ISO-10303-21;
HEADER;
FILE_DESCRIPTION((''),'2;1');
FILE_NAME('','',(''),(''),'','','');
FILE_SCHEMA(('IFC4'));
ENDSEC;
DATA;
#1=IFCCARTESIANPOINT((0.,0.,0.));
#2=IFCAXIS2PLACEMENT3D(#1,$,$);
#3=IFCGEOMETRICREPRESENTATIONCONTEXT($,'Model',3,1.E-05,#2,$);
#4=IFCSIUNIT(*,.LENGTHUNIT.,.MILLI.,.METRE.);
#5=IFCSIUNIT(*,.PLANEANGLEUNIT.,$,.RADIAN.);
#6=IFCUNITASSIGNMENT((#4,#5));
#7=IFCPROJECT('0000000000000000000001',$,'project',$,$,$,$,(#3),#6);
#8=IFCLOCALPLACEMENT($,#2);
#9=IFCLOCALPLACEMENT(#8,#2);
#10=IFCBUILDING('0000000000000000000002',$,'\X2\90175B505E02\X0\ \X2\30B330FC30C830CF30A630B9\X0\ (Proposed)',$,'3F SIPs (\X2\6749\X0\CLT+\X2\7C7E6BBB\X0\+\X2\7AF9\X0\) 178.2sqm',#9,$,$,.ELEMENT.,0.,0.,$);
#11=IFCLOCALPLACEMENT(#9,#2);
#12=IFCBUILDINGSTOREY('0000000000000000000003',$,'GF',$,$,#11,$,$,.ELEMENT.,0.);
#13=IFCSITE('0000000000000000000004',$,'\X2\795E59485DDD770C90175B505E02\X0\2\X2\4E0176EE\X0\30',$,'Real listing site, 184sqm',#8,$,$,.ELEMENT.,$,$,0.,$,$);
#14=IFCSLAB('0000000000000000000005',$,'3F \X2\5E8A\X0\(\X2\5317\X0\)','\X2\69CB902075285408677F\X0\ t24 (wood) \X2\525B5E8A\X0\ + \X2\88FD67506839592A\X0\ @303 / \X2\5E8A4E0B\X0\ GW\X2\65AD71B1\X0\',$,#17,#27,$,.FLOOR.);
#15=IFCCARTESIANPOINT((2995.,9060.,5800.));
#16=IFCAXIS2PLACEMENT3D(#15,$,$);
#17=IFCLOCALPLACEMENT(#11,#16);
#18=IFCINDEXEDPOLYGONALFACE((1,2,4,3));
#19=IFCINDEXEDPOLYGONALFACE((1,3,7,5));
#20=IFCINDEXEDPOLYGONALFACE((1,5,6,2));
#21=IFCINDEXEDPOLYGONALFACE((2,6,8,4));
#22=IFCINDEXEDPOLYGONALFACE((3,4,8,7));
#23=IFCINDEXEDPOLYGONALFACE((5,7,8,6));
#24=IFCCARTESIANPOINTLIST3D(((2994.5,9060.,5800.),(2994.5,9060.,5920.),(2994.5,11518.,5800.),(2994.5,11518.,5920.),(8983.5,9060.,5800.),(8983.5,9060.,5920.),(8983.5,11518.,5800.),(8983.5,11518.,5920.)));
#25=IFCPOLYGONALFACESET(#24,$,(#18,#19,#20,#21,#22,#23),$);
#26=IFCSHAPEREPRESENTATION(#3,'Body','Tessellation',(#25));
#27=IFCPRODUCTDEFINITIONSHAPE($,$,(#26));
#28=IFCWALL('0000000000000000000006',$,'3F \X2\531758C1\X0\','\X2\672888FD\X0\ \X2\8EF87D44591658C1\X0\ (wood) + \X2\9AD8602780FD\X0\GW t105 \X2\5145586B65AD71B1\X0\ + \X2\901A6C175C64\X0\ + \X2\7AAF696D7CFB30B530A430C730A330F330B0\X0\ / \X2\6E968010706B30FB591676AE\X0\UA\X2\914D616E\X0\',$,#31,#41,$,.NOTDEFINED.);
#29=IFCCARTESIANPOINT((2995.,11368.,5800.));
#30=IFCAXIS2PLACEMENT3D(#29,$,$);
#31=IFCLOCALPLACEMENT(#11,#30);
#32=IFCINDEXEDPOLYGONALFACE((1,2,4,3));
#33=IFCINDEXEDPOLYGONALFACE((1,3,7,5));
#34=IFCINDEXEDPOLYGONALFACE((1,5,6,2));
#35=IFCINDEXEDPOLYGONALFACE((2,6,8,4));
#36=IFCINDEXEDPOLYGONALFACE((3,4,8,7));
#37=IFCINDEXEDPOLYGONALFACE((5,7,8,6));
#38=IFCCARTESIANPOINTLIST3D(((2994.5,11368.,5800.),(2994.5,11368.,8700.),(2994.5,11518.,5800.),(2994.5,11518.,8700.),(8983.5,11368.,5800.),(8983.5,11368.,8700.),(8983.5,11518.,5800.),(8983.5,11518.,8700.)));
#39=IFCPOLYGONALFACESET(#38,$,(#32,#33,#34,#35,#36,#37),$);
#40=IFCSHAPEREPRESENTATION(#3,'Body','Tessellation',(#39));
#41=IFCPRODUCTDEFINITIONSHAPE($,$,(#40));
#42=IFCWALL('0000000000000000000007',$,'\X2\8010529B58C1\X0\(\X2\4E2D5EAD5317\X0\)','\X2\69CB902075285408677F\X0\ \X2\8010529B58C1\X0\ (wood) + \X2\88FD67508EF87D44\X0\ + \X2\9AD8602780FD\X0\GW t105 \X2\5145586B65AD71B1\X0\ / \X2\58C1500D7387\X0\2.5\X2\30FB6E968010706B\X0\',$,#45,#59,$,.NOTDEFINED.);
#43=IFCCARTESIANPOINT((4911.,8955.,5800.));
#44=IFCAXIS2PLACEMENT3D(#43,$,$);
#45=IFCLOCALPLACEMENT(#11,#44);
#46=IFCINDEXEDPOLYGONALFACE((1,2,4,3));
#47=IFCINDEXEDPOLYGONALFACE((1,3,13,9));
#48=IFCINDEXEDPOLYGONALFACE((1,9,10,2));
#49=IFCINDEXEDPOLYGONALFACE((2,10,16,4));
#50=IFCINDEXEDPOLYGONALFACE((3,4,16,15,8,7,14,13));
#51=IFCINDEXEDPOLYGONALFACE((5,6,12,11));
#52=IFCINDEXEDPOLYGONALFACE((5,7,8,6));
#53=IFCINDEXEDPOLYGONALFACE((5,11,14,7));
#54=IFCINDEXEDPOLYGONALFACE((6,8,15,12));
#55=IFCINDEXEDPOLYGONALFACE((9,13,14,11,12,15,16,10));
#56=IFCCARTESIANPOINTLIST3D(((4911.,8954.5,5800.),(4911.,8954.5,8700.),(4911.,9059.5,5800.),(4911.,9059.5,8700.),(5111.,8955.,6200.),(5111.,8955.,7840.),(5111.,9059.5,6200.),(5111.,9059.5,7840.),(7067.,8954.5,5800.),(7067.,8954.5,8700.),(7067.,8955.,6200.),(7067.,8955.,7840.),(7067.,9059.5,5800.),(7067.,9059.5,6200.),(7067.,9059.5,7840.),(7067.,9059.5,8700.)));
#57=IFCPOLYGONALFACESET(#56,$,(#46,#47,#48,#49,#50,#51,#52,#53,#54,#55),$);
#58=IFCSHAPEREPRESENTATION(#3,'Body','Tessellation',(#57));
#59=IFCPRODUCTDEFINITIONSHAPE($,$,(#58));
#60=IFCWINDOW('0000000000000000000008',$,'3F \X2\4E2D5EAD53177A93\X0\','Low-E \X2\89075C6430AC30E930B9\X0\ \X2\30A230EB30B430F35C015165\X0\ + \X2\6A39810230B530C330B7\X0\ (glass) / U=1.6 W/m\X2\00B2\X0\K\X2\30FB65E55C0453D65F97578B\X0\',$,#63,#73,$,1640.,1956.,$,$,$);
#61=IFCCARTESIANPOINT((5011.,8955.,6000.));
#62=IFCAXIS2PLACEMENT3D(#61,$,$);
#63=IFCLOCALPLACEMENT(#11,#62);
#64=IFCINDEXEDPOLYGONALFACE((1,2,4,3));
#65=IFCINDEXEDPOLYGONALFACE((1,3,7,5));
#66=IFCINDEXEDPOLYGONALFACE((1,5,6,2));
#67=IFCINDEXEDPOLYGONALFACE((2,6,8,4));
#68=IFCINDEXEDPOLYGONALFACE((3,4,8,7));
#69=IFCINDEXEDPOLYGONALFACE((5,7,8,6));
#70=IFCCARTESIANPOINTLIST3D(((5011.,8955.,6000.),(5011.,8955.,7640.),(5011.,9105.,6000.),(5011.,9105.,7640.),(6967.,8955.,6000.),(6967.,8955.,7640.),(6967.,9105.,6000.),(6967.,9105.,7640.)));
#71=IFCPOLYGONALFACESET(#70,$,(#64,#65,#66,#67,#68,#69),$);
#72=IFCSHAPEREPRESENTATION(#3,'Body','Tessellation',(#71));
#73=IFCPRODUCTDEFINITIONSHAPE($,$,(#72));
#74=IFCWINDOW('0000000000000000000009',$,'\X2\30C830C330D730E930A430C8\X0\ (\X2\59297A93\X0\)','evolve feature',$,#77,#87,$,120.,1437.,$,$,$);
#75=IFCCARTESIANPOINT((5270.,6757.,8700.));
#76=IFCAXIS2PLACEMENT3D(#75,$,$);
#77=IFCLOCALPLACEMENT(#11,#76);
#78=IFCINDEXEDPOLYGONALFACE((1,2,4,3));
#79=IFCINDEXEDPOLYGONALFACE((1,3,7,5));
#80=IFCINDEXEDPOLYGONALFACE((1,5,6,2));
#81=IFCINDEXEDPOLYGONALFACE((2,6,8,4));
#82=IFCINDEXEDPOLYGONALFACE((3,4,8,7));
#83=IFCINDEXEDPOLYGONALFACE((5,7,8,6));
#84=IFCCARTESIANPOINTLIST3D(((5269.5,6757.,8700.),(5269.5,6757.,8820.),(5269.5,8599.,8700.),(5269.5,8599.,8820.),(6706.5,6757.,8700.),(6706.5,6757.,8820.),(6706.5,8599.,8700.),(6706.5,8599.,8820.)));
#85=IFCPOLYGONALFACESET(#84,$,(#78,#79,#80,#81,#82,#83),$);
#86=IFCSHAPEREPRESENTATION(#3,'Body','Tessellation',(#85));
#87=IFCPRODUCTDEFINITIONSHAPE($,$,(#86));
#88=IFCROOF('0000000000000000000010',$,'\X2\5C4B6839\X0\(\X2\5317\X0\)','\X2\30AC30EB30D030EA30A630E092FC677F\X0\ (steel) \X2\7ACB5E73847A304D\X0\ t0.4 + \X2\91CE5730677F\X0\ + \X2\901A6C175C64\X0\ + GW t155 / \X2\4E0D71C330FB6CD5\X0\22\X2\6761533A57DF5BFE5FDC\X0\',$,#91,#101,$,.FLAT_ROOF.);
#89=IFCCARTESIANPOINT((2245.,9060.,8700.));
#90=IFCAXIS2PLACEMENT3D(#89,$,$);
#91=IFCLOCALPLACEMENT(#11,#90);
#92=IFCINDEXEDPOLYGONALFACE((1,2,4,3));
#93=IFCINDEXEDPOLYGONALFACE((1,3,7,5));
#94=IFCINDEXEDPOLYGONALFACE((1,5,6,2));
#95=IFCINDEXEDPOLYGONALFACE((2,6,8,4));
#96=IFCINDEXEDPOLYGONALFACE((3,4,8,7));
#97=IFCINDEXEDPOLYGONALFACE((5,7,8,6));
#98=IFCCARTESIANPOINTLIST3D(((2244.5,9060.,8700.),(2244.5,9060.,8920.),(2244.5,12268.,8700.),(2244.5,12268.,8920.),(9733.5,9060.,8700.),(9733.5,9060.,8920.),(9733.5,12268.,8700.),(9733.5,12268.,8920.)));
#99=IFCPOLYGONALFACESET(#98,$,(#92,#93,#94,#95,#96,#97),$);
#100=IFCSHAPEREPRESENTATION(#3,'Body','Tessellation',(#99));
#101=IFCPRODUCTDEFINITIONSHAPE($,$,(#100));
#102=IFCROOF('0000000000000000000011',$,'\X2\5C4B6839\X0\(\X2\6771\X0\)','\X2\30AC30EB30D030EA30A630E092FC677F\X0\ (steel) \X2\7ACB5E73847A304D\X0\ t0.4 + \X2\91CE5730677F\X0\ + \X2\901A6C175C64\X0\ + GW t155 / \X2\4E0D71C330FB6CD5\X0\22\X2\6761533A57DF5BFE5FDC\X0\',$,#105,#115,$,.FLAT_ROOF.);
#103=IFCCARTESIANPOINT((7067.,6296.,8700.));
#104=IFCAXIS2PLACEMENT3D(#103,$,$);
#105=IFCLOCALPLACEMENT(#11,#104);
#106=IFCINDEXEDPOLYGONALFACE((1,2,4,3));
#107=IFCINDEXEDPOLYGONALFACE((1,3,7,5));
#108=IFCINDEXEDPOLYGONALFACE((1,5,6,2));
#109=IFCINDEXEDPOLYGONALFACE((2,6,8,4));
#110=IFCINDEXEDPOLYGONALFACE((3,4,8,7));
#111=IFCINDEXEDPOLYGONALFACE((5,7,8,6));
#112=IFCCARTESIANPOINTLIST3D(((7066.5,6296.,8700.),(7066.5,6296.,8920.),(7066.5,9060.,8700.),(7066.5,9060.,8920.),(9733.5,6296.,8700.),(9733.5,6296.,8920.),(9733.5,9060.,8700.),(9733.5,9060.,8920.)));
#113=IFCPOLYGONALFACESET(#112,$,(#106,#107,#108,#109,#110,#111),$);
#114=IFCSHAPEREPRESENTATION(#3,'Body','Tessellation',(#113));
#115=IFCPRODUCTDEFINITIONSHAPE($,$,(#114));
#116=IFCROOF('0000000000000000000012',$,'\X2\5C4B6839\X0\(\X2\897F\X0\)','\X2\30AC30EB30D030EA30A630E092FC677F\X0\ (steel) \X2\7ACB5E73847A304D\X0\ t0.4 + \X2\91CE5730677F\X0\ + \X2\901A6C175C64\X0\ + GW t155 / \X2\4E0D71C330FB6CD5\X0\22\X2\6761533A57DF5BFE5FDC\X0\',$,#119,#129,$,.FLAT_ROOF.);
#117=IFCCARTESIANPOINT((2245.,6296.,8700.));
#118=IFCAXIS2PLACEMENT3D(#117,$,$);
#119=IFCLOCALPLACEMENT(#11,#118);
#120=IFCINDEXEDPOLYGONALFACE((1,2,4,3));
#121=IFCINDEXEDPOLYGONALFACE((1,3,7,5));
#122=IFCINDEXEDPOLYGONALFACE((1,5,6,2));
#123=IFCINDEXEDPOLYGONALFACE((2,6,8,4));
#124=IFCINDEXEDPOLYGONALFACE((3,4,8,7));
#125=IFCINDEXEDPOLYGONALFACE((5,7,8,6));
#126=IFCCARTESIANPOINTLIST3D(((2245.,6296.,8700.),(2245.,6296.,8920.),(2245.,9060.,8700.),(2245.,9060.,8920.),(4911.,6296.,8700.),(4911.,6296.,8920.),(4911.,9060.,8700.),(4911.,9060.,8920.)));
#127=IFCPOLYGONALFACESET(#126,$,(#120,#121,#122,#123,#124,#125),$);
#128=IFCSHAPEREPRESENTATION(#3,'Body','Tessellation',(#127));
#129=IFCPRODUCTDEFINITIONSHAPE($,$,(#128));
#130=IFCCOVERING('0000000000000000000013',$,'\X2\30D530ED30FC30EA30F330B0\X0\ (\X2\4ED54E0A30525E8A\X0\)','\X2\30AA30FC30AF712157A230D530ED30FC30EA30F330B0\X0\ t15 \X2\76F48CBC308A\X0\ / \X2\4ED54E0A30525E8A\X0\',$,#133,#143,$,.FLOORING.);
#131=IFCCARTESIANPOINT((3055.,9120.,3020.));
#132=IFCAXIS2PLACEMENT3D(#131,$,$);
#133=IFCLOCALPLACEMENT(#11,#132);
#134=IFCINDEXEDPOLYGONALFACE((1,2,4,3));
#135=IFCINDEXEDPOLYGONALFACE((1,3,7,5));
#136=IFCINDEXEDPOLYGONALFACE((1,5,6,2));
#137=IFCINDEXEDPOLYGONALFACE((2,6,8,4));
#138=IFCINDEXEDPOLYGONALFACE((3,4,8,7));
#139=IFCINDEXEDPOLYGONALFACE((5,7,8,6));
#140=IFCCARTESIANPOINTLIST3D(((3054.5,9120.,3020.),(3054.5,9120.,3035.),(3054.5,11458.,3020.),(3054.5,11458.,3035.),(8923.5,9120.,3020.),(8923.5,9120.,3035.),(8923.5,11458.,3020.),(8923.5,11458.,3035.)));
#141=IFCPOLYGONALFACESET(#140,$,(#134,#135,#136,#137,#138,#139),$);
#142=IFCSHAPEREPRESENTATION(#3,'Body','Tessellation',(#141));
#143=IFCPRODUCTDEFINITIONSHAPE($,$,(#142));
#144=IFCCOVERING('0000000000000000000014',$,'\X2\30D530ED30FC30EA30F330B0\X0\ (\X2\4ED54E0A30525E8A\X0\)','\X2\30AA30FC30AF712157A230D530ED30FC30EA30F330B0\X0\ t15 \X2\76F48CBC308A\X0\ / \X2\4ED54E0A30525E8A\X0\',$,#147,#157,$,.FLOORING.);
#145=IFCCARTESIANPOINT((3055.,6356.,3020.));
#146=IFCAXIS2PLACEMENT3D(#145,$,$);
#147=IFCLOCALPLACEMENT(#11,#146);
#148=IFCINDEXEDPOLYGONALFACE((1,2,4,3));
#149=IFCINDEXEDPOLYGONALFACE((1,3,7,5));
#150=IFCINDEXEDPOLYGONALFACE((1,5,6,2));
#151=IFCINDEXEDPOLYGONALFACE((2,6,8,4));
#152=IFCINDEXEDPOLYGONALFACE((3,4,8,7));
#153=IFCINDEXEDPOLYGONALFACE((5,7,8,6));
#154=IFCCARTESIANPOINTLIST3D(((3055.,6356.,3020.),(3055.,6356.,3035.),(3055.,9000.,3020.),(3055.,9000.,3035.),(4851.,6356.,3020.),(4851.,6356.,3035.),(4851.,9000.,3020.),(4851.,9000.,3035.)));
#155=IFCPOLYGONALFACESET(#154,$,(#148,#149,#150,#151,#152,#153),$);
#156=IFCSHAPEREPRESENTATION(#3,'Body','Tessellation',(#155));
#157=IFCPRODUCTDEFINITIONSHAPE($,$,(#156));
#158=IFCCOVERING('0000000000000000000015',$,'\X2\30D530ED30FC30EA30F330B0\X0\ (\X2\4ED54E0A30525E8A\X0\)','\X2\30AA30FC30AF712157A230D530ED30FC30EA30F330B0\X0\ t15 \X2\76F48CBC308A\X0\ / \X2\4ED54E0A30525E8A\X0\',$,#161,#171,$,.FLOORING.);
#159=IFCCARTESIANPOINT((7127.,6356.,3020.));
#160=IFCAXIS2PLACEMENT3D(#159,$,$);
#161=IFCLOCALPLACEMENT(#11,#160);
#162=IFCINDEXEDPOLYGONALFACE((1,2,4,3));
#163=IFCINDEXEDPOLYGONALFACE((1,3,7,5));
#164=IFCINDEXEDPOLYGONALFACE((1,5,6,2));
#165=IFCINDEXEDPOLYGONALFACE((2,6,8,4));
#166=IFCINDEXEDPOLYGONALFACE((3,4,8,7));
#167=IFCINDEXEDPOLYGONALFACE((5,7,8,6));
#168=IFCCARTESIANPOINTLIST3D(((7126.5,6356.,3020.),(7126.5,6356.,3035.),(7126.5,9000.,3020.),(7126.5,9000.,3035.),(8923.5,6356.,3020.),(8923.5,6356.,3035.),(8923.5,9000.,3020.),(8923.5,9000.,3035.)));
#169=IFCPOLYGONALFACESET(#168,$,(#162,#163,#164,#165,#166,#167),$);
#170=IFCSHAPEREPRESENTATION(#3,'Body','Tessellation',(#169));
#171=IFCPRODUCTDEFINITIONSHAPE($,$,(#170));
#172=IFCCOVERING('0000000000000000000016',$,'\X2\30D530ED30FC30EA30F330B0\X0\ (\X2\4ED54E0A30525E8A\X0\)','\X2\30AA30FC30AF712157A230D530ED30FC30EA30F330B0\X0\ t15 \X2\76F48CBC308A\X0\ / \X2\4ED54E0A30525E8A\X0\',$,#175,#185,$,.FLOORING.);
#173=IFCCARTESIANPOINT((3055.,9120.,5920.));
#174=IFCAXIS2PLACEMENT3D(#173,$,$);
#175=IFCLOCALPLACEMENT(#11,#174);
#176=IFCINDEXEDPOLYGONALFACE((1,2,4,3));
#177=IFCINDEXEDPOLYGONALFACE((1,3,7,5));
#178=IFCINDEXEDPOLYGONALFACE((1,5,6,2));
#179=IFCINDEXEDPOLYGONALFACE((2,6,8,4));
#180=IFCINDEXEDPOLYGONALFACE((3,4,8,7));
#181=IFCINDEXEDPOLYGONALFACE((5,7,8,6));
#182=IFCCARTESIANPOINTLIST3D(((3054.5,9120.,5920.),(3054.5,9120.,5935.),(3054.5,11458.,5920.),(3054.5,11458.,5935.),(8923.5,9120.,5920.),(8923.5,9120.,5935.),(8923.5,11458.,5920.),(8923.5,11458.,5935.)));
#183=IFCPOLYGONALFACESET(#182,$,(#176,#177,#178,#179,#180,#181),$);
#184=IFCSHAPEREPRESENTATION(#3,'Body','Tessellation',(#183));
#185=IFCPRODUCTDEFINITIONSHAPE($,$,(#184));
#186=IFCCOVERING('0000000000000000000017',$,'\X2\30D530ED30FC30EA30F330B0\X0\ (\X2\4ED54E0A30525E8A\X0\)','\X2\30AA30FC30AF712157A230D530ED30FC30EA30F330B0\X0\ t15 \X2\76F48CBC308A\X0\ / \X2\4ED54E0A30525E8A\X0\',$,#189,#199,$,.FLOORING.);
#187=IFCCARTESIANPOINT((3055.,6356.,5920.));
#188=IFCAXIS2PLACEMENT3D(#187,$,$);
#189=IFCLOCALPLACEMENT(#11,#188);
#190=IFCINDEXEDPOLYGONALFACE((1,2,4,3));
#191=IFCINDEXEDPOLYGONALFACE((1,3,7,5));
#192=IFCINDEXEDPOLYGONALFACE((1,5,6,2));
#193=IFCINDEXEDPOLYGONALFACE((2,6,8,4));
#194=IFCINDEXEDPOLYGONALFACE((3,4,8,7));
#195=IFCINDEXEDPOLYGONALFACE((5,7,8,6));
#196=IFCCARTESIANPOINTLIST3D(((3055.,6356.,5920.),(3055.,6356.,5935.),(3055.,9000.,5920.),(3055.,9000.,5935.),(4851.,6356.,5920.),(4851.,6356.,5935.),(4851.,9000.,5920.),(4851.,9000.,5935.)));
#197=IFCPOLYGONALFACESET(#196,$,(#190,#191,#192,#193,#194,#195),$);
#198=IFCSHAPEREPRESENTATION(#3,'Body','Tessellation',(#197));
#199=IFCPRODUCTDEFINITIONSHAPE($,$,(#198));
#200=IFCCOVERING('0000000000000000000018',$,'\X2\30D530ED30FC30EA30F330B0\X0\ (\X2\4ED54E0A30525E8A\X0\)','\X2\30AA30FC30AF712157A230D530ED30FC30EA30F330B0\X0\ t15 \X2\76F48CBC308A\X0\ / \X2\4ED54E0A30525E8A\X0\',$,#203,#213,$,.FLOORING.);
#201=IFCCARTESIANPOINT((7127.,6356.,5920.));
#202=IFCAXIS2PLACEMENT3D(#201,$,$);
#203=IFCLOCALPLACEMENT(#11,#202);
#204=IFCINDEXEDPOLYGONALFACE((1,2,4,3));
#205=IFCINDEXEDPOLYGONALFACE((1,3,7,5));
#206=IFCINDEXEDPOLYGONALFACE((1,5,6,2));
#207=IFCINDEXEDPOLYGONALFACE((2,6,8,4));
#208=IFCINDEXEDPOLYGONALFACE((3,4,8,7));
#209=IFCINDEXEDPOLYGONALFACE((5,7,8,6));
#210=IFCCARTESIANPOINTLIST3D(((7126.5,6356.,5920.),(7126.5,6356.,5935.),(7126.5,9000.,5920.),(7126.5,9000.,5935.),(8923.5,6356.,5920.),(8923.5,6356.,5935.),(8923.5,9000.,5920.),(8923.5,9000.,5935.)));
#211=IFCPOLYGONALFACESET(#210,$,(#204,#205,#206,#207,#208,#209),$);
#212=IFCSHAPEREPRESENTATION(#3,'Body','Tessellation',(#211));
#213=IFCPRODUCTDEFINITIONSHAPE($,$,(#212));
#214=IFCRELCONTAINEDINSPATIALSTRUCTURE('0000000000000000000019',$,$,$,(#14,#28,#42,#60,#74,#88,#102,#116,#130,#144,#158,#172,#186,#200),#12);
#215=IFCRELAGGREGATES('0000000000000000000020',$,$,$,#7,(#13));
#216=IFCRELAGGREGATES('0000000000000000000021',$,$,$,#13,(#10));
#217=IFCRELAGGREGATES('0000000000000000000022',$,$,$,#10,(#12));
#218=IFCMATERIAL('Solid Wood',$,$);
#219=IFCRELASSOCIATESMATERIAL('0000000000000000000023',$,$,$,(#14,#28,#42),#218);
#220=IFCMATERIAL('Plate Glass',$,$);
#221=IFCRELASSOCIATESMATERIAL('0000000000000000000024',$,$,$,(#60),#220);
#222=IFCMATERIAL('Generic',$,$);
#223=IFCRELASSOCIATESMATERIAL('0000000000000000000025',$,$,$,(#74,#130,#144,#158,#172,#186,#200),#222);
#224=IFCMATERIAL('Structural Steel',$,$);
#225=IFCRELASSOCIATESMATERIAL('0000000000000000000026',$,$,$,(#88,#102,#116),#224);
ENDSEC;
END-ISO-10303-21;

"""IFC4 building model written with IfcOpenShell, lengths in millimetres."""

from ifc_helpers import new_model, si_unit, frame, frame_2d, origin, place, context, project, spatial, rectangle, extrude, material, element, fill, save


model = new_model("IFC4")

# Units and contexts
model_context = context("Model", 3, precision=1e-05, world=origin())
ifc_project = project(units=[si_unit("LENGTHUNIT", "METRE", prefix="MILLI"), si_unit("PLANEANGLEUNIT", "RADIAN")], contexts=[model_context])

# Site, building, storey
site_placement = place(None, origin())
site = spatial("IfcSite", under=ifc_project, at=site_placement, Name="神奈川県逗子市2丁目30", ObjectType="Real listing site, 184sqm", CompositionType="ELEMENT", RefElevation=0.0)
building_placement = place(site_placement, origin())
building = spatial("IfcBuilding", under=site, at=building_placement, Name="逗子市 コートハウス (Proposed)", ObjectType="3F SIPs (杉CLT+籾殻+竹) 178.2sqm", CompositionType="ELEMENT", ElevationOfRefHeight=0.0, ElevationOfTerrain=0.0)
storey_placement = place(building_placement, origin())
storey = spatial("IfcBuildingStorey", under=building, at=storey_placement, Name="GF", CompositionType="ELEMENT", Elevation=0.0)

# Slab
ifc_material_1 = material(Name="Solid Wood")
slab_placement = place(storey_placement, frame((2995.0, 9060.0, 5800.0)))
element("IfcSlab", 1, at=slab_placement, inside=storey, material=ifc_material_1, Name="3F 床(北)", Description="構造用合板 t24 (wood) 剛床 + 製材根太 @303 / 床下 GW断熱", PredefinedType="FLOOR", context=model_context, shape_type="SweptSolid", body=[
    extrude(rectangle(XDim=5989.0, YDim=2458.0, at=frame_2d((2994.0, 1229.0))), frame((2995.0, 9060.0, 5800.0)), (0.0, 0.0, 1.0), 120.0),
])

# Wall
wall_1_placement = place(storey_placement, frame((2995.0, 11368.0, 5800.0)))
element("IfcWall", 2, at=wall_1_placement, inside=storey, material=ifc_material_1, Name="3F 北壁", Description="木製 軸組外壁 (wood) + 高性能GW t105 充填断熱 + 通気層 + 窯業系サイディング / 準耐火・外皮UA配慮", PredefinedType="NOTDEFINED", context=model_context, shape_type="SweptSolid", body=[
    extrude(rectangle(XDim=5989.0, YDim=150.0, at=frame_2d((2994.0, 75.0))), frame((2995.0, 11368.0, 5800.0)), (0.0, 0.0, 1.0), 2900.0),
])

# Wall, opening, window
wall_2_placement = place(storey_placement, frame((4911.0, 8955.0, 5800.0)))
wall_2 = element("IfcWall", 3, at=wall_2_placement, inside=storey, material=ifc_material_1, Name="耐力壁(中庭北)", Description="構造用合板 耐力壁 (wood) + 製材軸組 + 高性能GW t105 充填断熱 / 壁倍率2.5・準耐火", PredefinedType="NOTDEFINED", context=model_context, shape_type="SweptSolid", body=[
    extrude(rectangle(XDim=2156.0, YDim=105.0, at=frame_2d((1078.0, 52.0))), frame((4911.0, 8955.0, 5800.0)), (0.0, 0.0, 1.0), 2900.0),
])
opening_placement = place(storey_placement, frame((5011.0, 8955.0, 6000.0)))
opening = element("IfcOpeningElement", 4, at=opening_placement, cuts=wall_2, PredefinedType="NOTDEFINED", context=model_context, shape_type="SweptSolid", body=[
    extrude(rectangle(XDim=1956.0, YDim=150.0, at=frame_2d((978.0, 75.0))), frame((5011.0, 8955.0, 6000.0)), (0.0, 0.0, 1.0), 1640.0),
])
ifc_material_2 = material(Name="Plate Glass")
window_1_placement = place(storey_placement, frame((5011.0, 8955.0, 6000.0)))
window_1 = element("IfcWindow", 5, at=window_1_placement, inside=storey, material=ifc_material_2, Name="3F 中庭北窓", Description="Low-E 複層ガラス アルゴン封入 + 樹脂サッシ (glass) / U=1.6 W/m²K・日射取得型", OverallHeight=1640.0, OverallWidth=1956.0, context=model_context, shape_type="SweptSolid", body=[
    extrude(rectangle(XDim=1956.0, YDim=150.0, at=frame_2d((978.0, 75.0))), frame((5011.0, 8955.0, 6000.0)), (0.0, 0.0, 1.0), 1640.0),
])
fill(opening, window_1)

# Window
ifc_material_3 = material(Name="Generic")
window_2_placement = place(storey_placement, frame((5270.0, 6757.0, 8700.0)))
element("IfcWindow", 6, at=window_2_placement, inside=storey, material=ifc_material_3, Name="トップライト (天窓)", Description="evolve feature", OverallHeight=120.0, OverallWidth=1437.0, context=model_context, shape_type="SweptSolid", body=[
    extrude(rectangle(XDim=1437.0, YDim=1842.0, at=frame_2d((718.0, 921.0))), frame((5270.0, 6757.0, 8700.0)), (0.0, 0.0, 1.0), 120.0),
])

# Roofs
ifc_material_4 = material(Name="Structural Steel")
roof_1_placement = place(storey_placement, frame((2245.0, 9060.0, 8700.0)))
element("IfcRoof", 7, at=roof_1_placement, inside=storey, material=ifc_material_4, Name="屋根(北)", Description="ガルバリウム鋼板 (steel) 立平葺き t0.4 + 野地板 + 通気層 + GW t155 / 不燃・法22条区域対応", PredefinedType="FLAT_ROOF", context=model_context, shape_type="SweptSolid", body=[
    extrude(rectangle(XDim=7489.0, YDim=3208.0, at=frame_2d((3744.0, 1604.0))), frame((2245.0, 9060.0, 8700.0)), (0.0, 0.0, 1.0), 220.0),
])
roof_2_placement = place(storey_placement, frame((7067.0, 6296.0, 8700.0)))
element("IfcRoof", 8, at=roof_2_placement, inside=storey, material=ifc_material_4, Name="屋根(東)", Description="ガルバリウム鋼板 (steel) 立平葺き t0.4 + 野地板 + 通気層 + GW t155 / 不燃・法22条区域対応", PredefinedType="FLAT_ROOF", context=model_context, shape_type="SweptSolid", body=[
    extrude(rectangle(XDim=2667.0, YDim=2764.0, at=frame_2d((1333.0, 1382.0))), frame((7067.0, 6296.0, 8700.0)), (0.0, 0.0, 1.0), 220.0),
])
roof_3_placement = place(storey_placement, frame((2245.0, 6296.0, 8700.0)))
element("IfcRoof", 9, at=roof_3_placement, inside=storey, material=ifc_material_4, Name="屋根(西)", Description="ガルバリウム鋼板 (steel) 立平葺き t0.4 + 野地板 + 通気層 + GW t155 / 不燃・法22条区域対応", PredefinedType="FLAT_ROOF", context=model_context, shape_type="SweptSolid", body=[
    extrude(rectangle(XDim=2666.0, YDim=2764.0, at=frame_2d((1333.0, 1382.0))), frame((2245.0, 6296.0, 8700.0)), (0.0, 0.0, 1.0), 220.0),
])

# Coverings
covering_1_placement = place(storey_placement, frame((3055.0, 9120.0, 3020.0)))
element("IfcCovering", 10, at=covering_1_placement, inside=storey, material=ifc_material_3, Name="フローリング (仕上げ床)", Description="オーク無垢フローリング t15 直貼り / 仕上げ床", PredefinedType="FLOORING", context=model_context, shape_type="SweptSolid", body=[
    extrude(rectangle(XDim=5869.0, YDim=2338.0, at=frame_2d((2934.0, 1169.0))), frame((3055.0, 9120.0, 3020.0)), (0.0, 0.0, 1.0), 15.0),
])
covering_2_placement = place(storey_placement, frame((3055.0, 6356.0, 3020.0)))
element("IfcCovering", 11, at=covering_2_placement, inside=storey, material=ifc_material_3, Name="フローリング (仕上げ床)", Description="オーク無垢フローリング t15 直貼り / 仕上げ床", PredefinedType="FLOORING", context=model_context, shape_type="SweptSolid", body=[
    extrude(rectangle(XDim=1796.0, YDim=2644.0, at=frame_2d((898.0, 1322.0))), frame((3055.0, 6356.0, 3020.0)), (0.0, 0.0, 1.0), 15.0),
])
covering_3_placement = place(storey_placement, frame((7127.0, 6356.0, 3020.0)))
element("IfcCovering", 12, at=covering_3_placement, inside=storey, material=ifc_material_3, Name="フローリング (仕上げ床)", Description="オーク無垢フローリング t15 直貼り / 仕上げ床", PredefinedType="FLOORING", context=model_context, shape_type="SweptSolid", body=[
    extrude(rectangle(XDim=1797.0, YDim=2644.0, at=frame_2d((898.0, 1322.0))), frame((7127.0, 6356.0, 3020.0)), (0.0, 0.0, 1.0), 15.0),
])
covering_4_placement = place(storey_placement, frame((3055.0, 9120.0, 5920.0)))
element("IfcCovering", 13, at=covering_4_placement, inside=storey, material=ifc_material_3, Name="フローリング (仕上げ床)", Description="オーク無垢フローリング t15 直貼り / 仕上げ床", PredefinedType="FLOORING", context=model_context, shape_type="SweptSolid", body=[
    extrude(rectangle(XDim=5869.0, YDim=2338.0, at=frame_2d((2934.0, 1169.0))), frame((3055.0, 9120.0, 5920.0)), (0.0, 0.0, 1.0), 15.0),
])
covering_5_placement = place(storey_placement, frame((3055.0, 6356.0, 5920.0)))
element("IfcCovering", 14, at=covering_5_placement, inside=storey, material=ifc_material_3, Name="フローリング (仕上げ床)", Description="オーク無垢フローリング t15 直貼り / 仕上げ床", PredefinedType="FLOORING", context=model_context, shape_type="SweptSolid", body=[
    extrude(rectangle(XDim=1796.0, YDim=2644.0, at=frame_2d((898.0, 1322.0))), frame((3055.0, 6356.0, 5920.0)), (0.0, 0.0, 1.0), 15.0),
])
covering_6_placement = place(storey_placement, frame((7127.0, 6356.0, 5920.0)))
element("IfcCovering", 15, at=covering_6_placement, inside=storey, material=ifc_material_3, Name="フローリング (仕上げ床)", Description="オーク無垢フローリング t15 直貼り / 仕上げ床", PredefinedType="FLOORING", context=model_context, shape_type="SweptSolid", body=[
    extrude(rectangle(XDim=1797.0, YDim=2644.0, at=frame_2d((898.0, 1322.0))), frame((7127.0, 6356.0, 5920.0)), (0.0, 0.0, 1.0), 15.0),
])

save(model, "model.ifc")
